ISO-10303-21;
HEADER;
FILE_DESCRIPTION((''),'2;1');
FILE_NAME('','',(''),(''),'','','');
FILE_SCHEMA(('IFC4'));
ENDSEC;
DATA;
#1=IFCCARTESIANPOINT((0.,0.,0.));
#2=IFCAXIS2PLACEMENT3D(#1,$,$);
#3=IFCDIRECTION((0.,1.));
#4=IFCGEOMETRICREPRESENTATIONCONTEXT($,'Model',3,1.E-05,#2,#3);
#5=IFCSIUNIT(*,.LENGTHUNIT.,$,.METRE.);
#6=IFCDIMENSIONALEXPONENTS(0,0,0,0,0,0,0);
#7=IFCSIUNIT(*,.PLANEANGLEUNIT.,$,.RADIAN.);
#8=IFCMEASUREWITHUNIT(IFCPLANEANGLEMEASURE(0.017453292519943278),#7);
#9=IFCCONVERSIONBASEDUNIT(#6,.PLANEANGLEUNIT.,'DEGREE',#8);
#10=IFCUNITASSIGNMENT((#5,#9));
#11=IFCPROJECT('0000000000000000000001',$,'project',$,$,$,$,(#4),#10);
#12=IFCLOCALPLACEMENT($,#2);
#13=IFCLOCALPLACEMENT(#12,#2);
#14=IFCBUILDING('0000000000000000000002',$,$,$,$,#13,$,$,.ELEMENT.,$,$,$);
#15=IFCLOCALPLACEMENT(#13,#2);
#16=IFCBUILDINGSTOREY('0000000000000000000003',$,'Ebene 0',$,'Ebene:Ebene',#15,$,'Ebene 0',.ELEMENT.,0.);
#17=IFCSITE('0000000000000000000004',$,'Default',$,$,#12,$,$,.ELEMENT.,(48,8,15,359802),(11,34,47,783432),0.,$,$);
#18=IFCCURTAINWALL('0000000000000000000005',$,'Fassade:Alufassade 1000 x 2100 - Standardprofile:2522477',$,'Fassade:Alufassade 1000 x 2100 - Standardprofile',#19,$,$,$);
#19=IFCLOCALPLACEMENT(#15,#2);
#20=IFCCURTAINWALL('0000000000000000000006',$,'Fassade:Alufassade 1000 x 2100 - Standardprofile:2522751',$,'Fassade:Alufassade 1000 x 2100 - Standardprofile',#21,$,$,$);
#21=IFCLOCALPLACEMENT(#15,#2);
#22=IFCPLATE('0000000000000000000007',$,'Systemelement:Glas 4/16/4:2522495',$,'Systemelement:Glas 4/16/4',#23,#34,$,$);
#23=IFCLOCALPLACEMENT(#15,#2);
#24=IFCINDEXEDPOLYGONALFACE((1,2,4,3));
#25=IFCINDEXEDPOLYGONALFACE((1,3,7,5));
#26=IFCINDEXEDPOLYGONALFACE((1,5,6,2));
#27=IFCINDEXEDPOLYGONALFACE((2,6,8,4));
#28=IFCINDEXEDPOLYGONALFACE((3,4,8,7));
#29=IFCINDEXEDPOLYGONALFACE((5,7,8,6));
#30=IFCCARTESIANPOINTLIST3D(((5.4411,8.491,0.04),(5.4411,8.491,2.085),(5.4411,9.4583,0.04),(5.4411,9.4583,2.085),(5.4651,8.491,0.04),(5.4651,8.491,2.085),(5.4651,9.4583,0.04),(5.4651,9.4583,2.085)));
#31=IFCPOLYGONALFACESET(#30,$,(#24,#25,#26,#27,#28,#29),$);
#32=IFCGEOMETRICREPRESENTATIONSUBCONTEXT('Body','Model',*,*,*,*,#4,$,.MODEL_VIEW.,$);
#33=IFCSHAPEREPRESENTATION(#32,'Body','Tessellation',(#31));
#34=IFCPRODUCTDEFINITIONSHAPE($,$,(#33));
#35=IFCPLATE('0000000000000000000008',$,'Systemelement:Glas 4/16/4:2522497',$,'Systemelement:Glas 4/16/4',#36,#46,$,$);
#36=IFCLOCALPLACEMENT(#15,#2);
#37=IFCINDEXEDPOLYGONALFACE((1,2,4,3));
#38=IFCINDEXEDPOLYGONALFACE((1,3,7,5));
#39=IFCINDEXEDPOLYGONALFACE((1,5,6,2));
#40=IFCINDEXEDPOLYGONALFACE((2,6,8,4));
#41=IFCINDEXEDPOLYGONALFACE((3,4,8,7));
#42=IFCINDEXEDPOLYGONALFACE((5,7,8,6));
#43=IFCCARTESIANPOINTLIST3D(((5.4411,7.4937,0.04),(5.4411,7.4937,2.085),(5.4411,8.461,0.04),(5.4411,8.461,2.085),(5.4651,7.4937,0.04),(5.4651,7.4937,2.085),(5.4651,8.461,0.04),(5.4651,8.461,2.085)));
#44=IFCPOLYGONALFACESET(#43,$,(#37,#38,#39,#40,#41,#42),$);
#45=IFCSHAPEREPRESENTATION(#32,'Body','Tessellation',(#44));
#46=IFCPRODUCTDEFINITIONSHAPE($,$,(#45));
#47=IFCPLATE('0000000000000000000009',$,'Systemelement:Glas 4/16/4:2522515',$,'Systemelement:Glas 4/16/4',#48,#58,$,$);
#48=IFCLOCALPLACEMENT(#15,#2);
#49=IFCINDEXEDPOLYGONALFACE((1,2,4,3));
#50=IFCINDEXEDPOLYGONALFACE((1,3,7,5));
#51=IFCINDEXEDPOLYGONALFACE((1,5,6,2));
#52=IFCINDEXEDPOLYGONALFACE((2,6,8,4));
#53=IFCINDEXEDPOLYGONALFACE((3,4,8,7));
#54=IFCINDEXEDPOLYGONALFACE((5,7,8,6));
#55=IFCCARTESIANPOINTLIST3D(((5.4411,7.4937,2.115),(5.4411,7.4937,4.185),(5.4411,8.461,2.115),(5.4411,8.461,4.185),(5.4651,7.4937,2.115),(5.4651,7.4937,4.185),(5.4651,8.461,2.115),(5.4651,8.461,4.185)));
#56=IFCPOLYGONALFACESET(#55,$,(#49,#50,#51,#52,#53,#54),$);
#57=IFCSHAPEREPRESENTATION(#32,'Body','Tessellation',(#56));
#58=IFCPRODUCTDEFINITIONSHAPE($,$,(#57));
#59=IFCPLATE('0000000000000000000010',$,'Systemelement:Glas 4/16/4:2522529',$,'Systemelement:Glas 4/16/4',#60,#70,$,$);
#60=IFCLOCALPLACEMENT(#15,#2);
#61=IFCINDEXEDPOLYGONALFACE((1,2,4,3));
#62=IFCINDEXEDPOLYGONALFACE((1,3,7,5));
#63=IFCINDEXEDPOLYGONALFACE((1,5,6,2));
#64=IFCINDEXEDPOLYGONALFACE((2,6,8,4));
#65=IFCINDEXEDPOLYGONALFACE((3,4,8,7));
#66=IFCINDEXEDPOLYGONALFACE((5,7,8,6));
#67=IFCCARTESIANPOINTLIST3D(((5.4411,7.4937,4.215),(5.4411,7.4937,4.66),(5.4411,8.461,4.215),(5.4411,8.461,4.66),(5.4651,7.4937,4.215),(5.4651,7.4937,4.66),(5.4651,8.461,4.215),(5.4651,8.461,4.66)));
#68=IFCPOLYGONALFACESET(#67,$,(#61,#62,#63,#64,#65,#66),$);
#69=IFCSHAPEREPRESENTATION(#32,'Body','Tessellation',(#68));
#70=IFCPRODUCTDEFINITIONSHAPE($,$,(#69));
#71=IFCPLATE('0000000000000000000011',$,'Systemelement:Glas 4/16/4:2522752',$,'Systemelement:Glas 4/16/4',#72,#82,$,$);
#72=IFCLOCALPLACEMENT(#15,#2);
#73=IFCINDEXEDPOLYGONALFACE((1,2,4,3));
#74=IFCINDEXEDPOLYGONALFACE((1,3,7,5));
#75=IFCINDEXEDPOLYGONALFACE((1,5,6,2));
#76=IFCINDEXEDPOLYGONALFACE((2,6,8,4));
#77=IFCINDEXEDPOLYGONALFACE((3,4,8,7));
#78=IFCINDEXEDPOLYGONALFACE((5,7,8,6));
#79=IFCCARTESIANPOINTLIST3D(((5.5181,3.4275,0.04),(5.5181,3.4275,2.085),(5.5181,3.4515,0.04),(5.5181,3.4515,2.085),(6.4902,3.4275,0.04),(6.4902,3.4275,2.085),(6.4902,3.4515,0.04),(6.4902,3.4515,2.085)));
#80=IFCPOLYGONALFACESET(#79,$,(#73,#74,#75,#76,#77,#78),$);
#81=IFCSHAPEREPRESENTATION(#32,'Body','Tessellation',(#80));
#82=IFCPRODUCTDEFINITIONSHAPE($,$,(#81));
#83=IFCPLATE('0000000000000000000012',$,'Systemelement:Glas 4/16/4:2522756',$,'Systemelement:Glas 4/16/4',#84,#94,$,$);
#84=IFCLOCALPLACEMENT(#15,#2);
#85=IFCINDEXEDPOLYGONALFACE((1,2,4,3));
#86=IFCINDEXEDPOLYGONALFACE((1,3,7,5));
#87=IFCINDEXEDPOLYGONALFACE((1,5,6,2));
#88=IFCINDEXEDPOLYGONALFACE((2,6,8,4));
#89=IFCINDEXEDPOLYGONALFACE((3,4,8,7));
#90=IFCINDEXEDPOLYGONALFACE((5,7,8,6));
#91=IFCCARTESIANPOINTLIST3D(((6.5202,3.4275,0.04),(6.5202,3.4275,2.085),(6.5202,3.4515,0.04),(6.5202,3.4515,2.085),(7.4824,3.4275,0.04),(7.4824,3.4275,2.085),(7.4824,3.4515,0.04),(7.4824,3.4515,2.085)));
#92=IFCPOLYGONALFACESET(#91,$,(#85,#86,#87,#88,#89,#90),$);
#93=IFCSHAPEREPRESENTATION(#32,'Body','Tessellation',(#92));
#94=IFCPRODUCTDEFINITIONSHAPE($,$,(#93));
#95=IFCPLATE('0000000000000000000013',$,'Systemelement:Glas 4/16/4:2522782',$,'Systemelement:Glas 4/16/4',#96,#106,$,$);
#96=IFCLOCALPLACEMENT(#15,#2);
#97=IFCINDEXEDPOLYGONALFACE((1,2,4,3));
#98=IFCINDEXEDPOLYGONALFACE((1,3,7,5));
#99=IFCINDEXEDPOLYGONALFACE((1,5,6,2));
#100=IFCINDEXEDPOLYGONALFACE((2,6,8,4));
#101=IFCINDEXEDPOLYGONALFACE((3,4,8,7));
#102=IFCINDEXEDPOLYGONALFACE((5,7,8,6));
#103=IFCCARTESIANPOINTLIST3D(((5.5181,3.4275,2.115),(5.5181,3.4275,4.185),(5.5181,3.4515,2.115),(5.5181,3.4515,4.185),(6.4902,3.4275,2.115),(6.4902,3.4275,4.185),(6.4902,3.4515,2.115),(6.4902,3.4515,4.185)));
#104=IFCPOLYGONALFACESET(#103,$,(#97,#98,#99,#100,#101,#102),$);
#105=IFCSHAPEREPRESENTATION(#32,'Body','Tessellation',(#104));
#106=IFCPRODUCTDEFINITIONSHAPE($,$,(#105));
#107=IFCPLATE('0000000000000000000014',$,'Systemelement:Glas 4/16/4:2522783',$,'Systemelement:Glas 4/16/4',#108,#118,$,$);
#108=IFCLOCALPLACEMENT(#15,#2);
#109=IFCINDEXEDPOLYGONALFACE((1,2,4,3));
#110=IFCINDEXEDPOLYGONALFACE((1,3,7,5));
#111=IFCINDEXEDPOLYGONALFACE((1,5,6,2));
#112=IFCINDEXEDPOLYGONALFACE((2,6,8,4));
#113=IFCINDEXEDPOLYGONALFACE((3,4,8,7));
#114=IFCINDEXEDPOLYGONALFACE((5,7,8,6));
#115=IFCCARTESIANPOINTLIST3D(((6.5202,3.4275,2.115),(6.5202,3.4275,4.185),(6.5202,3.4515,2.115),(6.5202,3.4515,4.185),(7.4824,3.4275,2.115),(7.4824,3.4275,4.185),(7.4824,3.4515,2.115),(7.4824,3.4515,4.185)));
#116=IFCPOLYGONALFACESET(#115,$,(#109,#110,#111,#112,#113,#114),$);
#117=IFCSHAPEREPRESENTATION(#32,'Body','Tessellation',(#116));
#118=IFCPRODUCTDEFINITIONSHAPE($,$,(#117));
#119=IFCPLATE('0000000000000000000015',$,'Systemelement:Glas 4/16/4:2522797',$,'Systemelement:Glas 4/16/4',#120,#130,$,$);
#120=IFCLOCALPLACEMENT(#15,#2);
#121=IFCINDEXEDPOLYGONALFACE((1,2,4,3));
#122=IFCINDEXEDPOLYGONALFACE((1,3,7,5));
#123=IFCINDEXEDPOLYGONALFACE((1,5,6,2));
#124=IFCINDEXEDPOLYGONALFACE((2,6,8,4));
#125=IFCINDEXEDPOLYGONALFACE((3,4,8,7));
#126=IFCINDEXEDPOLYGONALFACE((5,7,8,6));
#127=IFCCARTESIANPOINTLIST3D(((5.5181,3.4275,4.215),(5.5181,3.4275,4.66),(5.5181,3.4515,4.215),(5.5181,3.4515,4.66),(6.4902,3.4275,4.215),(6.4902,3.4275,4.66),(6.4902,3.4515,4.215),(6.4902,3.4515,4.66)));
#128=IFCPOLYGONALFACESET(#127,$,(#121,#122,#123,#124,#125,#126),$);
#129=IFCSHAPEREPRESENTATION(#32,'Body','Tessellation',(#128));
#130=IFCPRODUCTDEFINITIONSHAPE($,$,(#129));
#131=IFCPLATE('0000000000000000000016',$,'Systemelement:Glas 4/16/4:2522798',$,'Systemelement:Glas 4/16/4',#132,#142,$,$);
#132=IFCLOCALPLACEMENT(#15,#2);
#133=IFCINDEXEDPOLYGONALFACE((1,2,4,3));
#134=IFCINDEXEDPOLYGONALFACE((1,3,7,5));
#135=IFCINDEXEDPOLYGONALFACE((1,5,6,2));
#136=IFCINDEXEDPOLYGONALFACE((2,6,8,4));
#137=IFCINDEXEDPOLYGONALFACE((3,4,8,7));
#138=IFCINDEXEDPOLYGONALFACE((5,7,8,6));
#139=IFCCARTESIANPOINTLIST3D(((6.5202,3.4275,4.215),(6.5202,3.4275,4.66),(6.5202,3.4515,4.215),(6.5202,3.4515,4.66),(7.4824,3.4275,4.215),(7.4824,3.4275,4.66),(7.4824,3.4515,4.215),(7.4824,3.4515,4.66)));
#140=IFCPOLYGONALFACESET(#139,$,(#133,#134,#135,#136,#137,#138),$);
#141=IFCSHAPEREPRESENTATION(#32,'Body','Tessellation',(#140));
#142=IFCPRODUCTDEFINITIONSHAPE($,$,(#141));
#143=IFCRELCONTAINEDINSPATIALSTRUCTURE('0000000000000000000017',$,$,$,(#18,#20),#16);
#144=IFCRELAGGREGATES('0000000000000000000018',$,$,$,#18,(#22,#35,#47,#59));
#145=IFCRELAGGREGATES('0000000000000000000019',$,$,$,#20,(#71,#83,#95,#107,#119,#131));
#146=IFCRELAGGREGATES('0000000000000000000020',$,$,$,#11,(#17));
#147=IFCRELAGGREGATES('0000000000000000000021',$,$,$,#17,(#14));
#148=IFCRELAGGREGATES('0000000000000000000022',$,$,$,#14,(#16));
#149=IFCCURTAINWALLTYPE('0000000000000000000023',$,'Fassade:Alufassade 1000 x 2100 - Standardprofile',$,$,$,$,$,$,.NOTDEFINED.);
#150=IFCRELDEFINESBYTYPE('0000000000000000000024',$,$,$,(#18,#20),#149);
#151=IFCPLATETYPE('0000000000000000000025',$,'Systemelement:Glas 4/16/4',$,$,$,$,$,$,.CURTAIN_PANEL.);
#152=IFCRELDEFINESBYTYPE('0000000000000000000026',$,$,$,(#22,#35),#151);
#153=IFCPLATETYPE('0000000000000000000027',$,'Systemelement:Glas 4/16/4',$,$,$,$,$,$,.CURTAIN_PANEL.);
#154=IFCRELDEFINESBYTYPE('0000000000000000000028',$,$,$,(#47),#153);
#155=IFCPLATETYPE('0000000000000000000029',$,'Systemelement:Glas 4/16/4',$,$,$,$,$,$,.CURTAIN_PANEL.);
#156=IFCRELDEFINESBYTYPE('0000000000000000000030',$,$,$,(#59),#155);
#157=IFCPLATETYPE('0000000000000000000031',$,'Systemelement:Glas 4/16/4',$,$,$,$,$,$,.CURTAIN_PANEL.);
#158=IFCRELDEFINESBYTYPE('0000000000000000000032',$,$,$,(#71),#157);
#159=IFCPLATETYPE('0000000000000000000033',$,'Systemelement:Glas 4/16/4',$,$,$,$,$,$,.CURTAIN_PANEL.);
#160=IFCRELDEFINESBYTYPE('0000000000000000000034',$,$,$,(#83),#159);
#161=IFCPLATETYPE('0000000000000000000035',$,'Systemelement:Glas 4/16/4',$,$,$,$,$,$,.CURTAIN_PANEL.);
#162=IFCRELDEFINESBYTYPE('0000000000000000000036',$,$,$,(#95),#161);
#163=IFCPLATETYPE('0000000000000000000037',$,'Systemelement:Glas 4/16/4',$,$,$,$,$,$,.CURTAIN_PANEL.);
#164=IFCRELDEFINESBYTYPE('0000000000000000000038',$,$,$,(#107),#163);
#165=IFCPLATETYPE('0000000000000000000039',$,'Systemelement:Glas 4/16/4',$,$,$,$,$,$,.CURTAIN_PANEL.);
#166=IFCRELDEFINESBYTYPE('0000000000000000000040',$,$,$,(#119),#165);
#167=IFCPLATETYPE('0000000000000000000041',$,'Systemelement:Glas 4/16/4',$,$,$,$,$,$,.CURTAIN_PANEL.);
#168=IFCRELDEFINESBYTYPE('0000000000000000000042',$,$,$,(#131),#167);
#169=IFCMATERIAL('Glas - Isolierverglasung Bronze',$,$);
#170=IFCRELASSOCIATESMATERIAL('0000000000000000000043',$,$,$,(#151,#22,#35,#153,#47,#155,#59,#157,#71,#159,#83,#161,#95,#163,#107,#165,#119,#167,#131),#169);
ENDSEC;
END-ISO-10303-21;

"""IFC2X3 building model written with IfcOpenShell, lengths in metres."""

from ifc_helpers import new_model, entity, si_unit, converted_unit, direction, frame, origin, origin_2d_with_axis, place, context, subcontext, project, spatial, rectangle, extrude, source, transform, mapped, material, type_object, type_shapes, element, aggregate, save


model = new_model("IFC2X3")

# Units and contexts
model_context = context("Model", 3, precision=1e-05, world=origin(), true_north=direction((0.0, 1.0)))
body_context = subcontext(model_context, "Body", "Model", "MODEL_VIEW")
ifc_project = project(units=[si_unit("LENGTHUNIT", "METRE"), converted_unit("PLANEANGLEUNIT", "DEGREE", entity("IfcPlaneAngleMeasure", 0.017453292519943278), si_unit("PLANEANGLEUNIT", "RADIAN"), dimensions=[0, 0, 0, 0, 0, 0, 0])], contexts=[model_context])

# Site, building, storey
site_placement = place(None, origin())
site = spatial("IfcSite", under=ifc_project, at=site_placement, Name="Default", CompositionType="ELEMENT", RefLatitude=(48, 8, 15, 359802), RefLongitude=(11, 34, 47, 783432), RefElevation=0.0)
building_placement = place(site_placement, origin())
building = spatial("IfcBuilding", under=site, at=building_placement, CompositionType="ELEMENT")
storey_placement = place(building_placement, origin())
storey = spatial("IfcBuildingStorey", under=building, at=storey_placement, Name="Ebene 0", ObjectType="Ebene:Ebene", LongName="Ebene 0", CompositionType="ELEMENT", Elevation=0.0)

# Curtain walls
curtain_wall_type = type_object("IfcCurtainWallType", Name="Fassade:Alufassade 1000 x 2100 - Standardprofile", PredefinedType="NOTDEFINED")
curtain_wall_1_placement = place(storey_placement, origin())
curtain_wall_1 = element("IfcCurtainWall", 1, at=curtain_wall_1_placement, inside=storey, type_object=curtain_wall_type, Name="Fassade:Alufassade 1000 x 2100 - Standardprofile:2522477", ObjectType="Fassade:Alufassade 1000 x 2100 - Standardprofile")
curtain_wall_2_placement = place(storey_placement, origin())
curtain_wall_2 = element("IfcCurtainWall", 2, at=curtain_wall_2_placement, inside=storey, type_object=curtain_wall_type, Name="Fassade:Alufassade 1000 x 2100 - Standardprofile:2522751", ObjectType="Fassade:Alufassade 1000 x 2100 - Standardprofile")

# Plates
ifc_material_1 = material(Name="Glas - Isolierverglasung Bronze")
plate_type_1 = type_object("IfcPlateType", Name="Systemelement:Glas 4/16/4", PredefinedType="CURTAIN_PANEL", material=ifc_material_1)
shared_shape_1 = source(origin(), body_context, "Body", "SweptSolid", [
    extrude(rectangle(XDim=0.024, YDim=0.9673, at=origin_2d_with_axis()), frame((0.0, 0.0, 0.0), z_axis=(0.0, 0.0, 1.0), x_axis=(0.0, 1.0, 0.0)), (0.0, 0.0, 1.0), 2.045),
])
type_shapes(plate_type_1, [shared_shape_1])
plate_1_placement = place(curtain_wall_1_placement, frame((5.4531, 8.9747, 0.04), z_axis=(0.0, 0.0, 1.0), x_axis=(0.0, -1.0, 0.0)))
plate_1 = element("IfcPlate", 3, at=plate_1_placement, type_object=plate_type_1, material=ifc_material_1, Name="Systemelement:Glas 4/16/4:2522495", ObjectType="Systemelement:Glas 4/16/4", context=body_context, shape_type="MappedRepresentation", body=[
    mapped(shared_shape_1, transform((0.0, 0.0, 0.0), scale=1.0)),
])
plate_2_placement = place(curtain_wall_1_placement, frame((5.4531, 7.9774, 0.04), z_axis=(0.0, 0.0, 1.0), x_axis=(0.0, -1.0, 0.0)))
plate_2 = element("IfcPlate", 4, at=plate_2_placement, type_object=plate_type_1, material=ifc_material_1, Name="Systemelement:Glas 4/16/4:2522497", ObjectType="Systemelement:Glas 4/16/4", context=body_context, shape_type="MappedRepresentation", body=[
    mapped(shared_shape_1, transform((0.0, 0.0, 0.0), scale=1.0)),
])
plate_type_2 = type_object("IfcPlateType", Name="Systemelement:Glas 4/16/4", PredefinedType="CURTAIN_PANEL", material=ifc_material_1)
shared_shape_2 = source(origin(), body_context, "Body", "SweptSolid", [
    extrude(rectangle(XDim=0.024, YDim=0.9673, at=origin_2d_with_axis()), frame((0.0, 0.0, 0.0), z_axis=(0.0, 0.0, 1.0), x_axis=(0.0, 1.0, 0.0)), (0.0, 0.0, 1.0), 2.07),
])
type_shapes(plate_type_2, [shared_shape_2])
plate_3_placement = place(curtain_wall_1_placement, frame((5.4531, 7.9774, 2.115), z_axis=(0.0, 0.0, 1.0), x_axis=(0.0, -1.0, 0.0)))
plate_3 = element("IfcPlate", 5, at=plate_3_placement, type_object=plate_type_2, material=ifc_material_1, Name="Systemelement:Glas 4/16/4:2522515", ObjectType="Systemelement:Glas 4/16/4", context=body_context, shape_type="MappedRepresentation", body=[
    mapped(shared_shape_2, transform((0.0, 0.0, 0.0), scale=1.0)),
])
plate_type_3 = type_object("IfcPlateType", Name="Systemelement:Glas 4/16/4", PredefinedType="CURTAIN_PANEL", material=ifc_material_1)
shared_shape_3 = source(origin(), body_context, "Body", "SweptSolid", [
    extrude(rectangle(XDim=0.024, YDim=0.9673, at=origin_2d_with_axis()), frame((0.0, 0.0, 0.0), z_axis=(0.0, 0.0, 1.0), x_axis=(0.0, 1.0, 0.0)), (0.0, 0.0, 1.0), 0.445),
])
type_shapes(plate_type_3, [shared_shape_3])
plate_4_placement = place(curtain_wall_1_placement, frame((5.4531, 7.9774, 4.215), z_axis=(0.0, 0.0, 1.0), x_axis=(0.0, -1.0, 0.0)))
plate_4 = element("IfcPlate", 6, at=plate_4_placement, type_object=plate_type_3, material=ifc_material_1, Name="Systemelement:Glas 4/16/4:2522529", ObjectType="Systemelement:Glas 4/16/4", context=body_context, shape_type="MappedRepresentation", body=[
    mapped(shared_shape_3, transform((0.0, 0.0, 0.0), scale=1.0)),
])
aggregate(curtain_wall_1, [plate_1, plate_2, plate_3, plate_4])
plate_type_4 = type_object("IfcPlateType", Name="Systemelement:Glas 4/16/4", PredefinedType="CURTAIN_PANEL", material=ifc_material_1)
shared_shape_4 = source(origin(), body_context, "Body", "SweptSolid", [
    extrude(rectangle(XDim=0.024, YDim=0.9721, at=origin_2d_with_axis()), frame((0.0, 0.0, 0.0), z_axis=(0.0, 0.0, 1.0), x_axis=(0.0, 1.0, 0.0)), (0.0, 0.0, 1.0), 2.045),
])
type_shapes(plate_type_4, [shared_shape_4])
plate_5_placement = place(curtain_wall_2_placement, frame((6.0042, 3.4395, 0.04)))
plate_5 = element("IfcPlate", 7, at=plate_5_placement, type_object=plate_type_4, material=ifc_material_1, Name="Systemelement:Glas 4/16/4:2522752", ObjectType="Systemelement:Glas 4/16/4", context=body_context, shape_type="MappedRepresentation", body=[
    mapped(shared_shape_4, transform((0.0, 0.0, 0.0), scale=1.0)),
])
plate_type_5 = type_object("IfcPlateType", Name="Systemelement:Glas 4/16/4", PredefinedType="CURTAIN_PANEL", material=ifc_material_1)
shared_shape_5 = source(origin(), body_context, "Body", "SweptSolid", [
    extrude(rectangle(XDim=0.024, YDim=0.9621, at=origin_2d_with_axis()), frame((0.0, 0.0, 0.0), z_axis=(0.0, 0.0, 1.0), x_axis=(0.0, 1.0, 0.0)), (0.0, 0.0, 1.0), 2.045),
])
type_shapes(plate_type_5, [shared_shape_5])
plate_6_placement = place(curtain_wall_2_placement, frame((7.0013, 3.4395, 0.04)))
plate_6 = element("IfcPlate", 8, at=plate_6_placement, type_object=plate_type_5, material=ifc_material_1, Name="Systemelement:Glas 4/16/4:2522756", ObjectType="Systemelement:Glas 4/16/4", context=body_context, shape_type="MappedRepresentation", body=[
    mapped(shared_shape_5, transform((0.0, 0.0, 0.0), scale=1.0)),
])
plate_type_6 = type_object("IfcPlateType", Name="Systemelement:Glas 4/16/4", PredefinedType="CURTAIN_PANEL", material=ifc_material_1)
shared_shape_6 = source(origin(), body_context, "Body", "SweptSolid", [
    extrude(rectangle(XDim=0.024, YDim=0.9721, at=origin_2d_with_axis()), frame((0.0, 0.0, 0.0), z_axis=(0.0, 0.0, 1.0), x_axis=(0.0, 1.0, 0.0)), (0.0, 0.0, 1.0), 2.07),
])
type_shapes(plate_type_6, [shared_shape_6])
plate_7_placement = place(curtain_wall_2_placement, frame((6.0042, 3.4395, 2.115)))
plate_7 = element("IfcPlate", 9, at=plate_7_placement, type_object=plate_type_6, material=ifc_material_1, Name="Systemelement:Glas 4/16/4:2522782", ObjectType="Systemelement:Glas 4/16/4", context=body_context, shape_type="MappedRepresentation", body=[
    mapped(shared_shape_6, transform((0.0, 0.0, 0.0), scale=1.0)),
])
plate_type_7 = type_object("IfcPlateType", Name="Systemelement:Glas 4/16/4", PredefinedType="CURTAIN_PANEL", material=ifc_material_1)
shared_shape_7 = source(origin(), body_context, "Body", "SweptSolid", [
    extrude(rectangle(XDim=0.024, YDim=0.9621, at=origin_2d_with_axis()), frame((0.0, 0.0, 0.0), z_axis=(0.0, 0.0, 1.0), x_axis=(0.0, 1.0, 0.0)), (0.0, 0.0, 1.0), 2.07),
])
type_shapes(plate_type_7, [shared_shape_7])
plate_8_placement = place(curtain_wall_2_placement, frame((7.0013, 3.4395, 2.115)))
plate_8 = element("IfcPlate", 10, at=plate_8_placement, type_object=plate_type_7, material=ifc_material_1, Name="Systemelement:Glas 4/16/4:2522783", ObjectType="Systemelement:Glas 4/16/4", context=body_context, shape_type="MappedRepresentation", body=[
    mapped(shared_shape_7, transform((0.0, 0.0, 0.0), scale=1.0)),
])
plate_type_8 = type_object("IfcPlateType", Name="Systemelement:Glas 4/16/4", PredefinedType="CURTAIN_PANEL", material=ifc_material_1)
shared_shape_8 = source(origin(), body_context, "Body", "SweptSolid", [
    extrude(rectangle(XDim=0.024, YDim=0.9721, at=origin_2d_with_axis()), frame((0.0, 0.0, 0.0), z_axis=(0.0, 0.0, 1.0), x_axis=(0.0, 1.0, 0.0)), (0.0, 0.0, 1.0), 0.445),
])
type_shapes(plate_type_8, [shared_shape_8])
plate_9_placement = place(curtain_wall_2_placement, frame((6.0042, 3.4395, 4.215)))
plate_9 = element("IfcPlate", 11, at=plate_9_placement, type_object=plate_type_8, material=ifc_material_1, Name="Systemelement:Glas 4/16/4:2522797", ObjectType="Systemelement:Glas 4/16/4", context=body_context, shape_type="MappedRepresentation", body=[
    mapped(shared_shape_8, transform((0.0, 0.0, 0.0), scale=1.0)),
])
plate_type_9 = type_object("IfcPlateType", Name="Systemelement:Glas 4/16/4", PredefinedType="CURTAIN_PANEL", material=ifc_material_1)
shared_shape_9 = source(origin(), body_context, "Body", "SweptSolid", [
    extrude(rectangle(XDim=0.024, YDim=0.9621, at=origin_2d_with_axis()), frame((0.0, 0.0, 0.0), z_axis=(0.0, 0.0, 1.0), x_axis=(0.0, 1.0, 0.0)), (0.0, 0.0, 1.0), 0.445),
])
type_shapes(plate_type_9, [shared_shape_9])
plate_10_placement = place(curtain_wall_2_placement, frame((7.0013, 3.4395, 4.215)))
plate_10 = element("IfcPlate", 12, at=plate_10_placement, type_object=plate_type_9, material=ifc_material_1, Name="Systemelement:Glas 4/16/4:2522798", ObjectType="Systemelement:Glas 4/16/4", context=body_context, shape_type="MappedRepresentation", body=[
    mapped(shared_shape_9, transform((0.0, 0.0, 0.0), scale=1.0)),
])
aggregate(curtain_wall_2, [plate_5, plate_6, plate_7, plate_8, plate_9, plate_10])

save(model, "model.ifc")
